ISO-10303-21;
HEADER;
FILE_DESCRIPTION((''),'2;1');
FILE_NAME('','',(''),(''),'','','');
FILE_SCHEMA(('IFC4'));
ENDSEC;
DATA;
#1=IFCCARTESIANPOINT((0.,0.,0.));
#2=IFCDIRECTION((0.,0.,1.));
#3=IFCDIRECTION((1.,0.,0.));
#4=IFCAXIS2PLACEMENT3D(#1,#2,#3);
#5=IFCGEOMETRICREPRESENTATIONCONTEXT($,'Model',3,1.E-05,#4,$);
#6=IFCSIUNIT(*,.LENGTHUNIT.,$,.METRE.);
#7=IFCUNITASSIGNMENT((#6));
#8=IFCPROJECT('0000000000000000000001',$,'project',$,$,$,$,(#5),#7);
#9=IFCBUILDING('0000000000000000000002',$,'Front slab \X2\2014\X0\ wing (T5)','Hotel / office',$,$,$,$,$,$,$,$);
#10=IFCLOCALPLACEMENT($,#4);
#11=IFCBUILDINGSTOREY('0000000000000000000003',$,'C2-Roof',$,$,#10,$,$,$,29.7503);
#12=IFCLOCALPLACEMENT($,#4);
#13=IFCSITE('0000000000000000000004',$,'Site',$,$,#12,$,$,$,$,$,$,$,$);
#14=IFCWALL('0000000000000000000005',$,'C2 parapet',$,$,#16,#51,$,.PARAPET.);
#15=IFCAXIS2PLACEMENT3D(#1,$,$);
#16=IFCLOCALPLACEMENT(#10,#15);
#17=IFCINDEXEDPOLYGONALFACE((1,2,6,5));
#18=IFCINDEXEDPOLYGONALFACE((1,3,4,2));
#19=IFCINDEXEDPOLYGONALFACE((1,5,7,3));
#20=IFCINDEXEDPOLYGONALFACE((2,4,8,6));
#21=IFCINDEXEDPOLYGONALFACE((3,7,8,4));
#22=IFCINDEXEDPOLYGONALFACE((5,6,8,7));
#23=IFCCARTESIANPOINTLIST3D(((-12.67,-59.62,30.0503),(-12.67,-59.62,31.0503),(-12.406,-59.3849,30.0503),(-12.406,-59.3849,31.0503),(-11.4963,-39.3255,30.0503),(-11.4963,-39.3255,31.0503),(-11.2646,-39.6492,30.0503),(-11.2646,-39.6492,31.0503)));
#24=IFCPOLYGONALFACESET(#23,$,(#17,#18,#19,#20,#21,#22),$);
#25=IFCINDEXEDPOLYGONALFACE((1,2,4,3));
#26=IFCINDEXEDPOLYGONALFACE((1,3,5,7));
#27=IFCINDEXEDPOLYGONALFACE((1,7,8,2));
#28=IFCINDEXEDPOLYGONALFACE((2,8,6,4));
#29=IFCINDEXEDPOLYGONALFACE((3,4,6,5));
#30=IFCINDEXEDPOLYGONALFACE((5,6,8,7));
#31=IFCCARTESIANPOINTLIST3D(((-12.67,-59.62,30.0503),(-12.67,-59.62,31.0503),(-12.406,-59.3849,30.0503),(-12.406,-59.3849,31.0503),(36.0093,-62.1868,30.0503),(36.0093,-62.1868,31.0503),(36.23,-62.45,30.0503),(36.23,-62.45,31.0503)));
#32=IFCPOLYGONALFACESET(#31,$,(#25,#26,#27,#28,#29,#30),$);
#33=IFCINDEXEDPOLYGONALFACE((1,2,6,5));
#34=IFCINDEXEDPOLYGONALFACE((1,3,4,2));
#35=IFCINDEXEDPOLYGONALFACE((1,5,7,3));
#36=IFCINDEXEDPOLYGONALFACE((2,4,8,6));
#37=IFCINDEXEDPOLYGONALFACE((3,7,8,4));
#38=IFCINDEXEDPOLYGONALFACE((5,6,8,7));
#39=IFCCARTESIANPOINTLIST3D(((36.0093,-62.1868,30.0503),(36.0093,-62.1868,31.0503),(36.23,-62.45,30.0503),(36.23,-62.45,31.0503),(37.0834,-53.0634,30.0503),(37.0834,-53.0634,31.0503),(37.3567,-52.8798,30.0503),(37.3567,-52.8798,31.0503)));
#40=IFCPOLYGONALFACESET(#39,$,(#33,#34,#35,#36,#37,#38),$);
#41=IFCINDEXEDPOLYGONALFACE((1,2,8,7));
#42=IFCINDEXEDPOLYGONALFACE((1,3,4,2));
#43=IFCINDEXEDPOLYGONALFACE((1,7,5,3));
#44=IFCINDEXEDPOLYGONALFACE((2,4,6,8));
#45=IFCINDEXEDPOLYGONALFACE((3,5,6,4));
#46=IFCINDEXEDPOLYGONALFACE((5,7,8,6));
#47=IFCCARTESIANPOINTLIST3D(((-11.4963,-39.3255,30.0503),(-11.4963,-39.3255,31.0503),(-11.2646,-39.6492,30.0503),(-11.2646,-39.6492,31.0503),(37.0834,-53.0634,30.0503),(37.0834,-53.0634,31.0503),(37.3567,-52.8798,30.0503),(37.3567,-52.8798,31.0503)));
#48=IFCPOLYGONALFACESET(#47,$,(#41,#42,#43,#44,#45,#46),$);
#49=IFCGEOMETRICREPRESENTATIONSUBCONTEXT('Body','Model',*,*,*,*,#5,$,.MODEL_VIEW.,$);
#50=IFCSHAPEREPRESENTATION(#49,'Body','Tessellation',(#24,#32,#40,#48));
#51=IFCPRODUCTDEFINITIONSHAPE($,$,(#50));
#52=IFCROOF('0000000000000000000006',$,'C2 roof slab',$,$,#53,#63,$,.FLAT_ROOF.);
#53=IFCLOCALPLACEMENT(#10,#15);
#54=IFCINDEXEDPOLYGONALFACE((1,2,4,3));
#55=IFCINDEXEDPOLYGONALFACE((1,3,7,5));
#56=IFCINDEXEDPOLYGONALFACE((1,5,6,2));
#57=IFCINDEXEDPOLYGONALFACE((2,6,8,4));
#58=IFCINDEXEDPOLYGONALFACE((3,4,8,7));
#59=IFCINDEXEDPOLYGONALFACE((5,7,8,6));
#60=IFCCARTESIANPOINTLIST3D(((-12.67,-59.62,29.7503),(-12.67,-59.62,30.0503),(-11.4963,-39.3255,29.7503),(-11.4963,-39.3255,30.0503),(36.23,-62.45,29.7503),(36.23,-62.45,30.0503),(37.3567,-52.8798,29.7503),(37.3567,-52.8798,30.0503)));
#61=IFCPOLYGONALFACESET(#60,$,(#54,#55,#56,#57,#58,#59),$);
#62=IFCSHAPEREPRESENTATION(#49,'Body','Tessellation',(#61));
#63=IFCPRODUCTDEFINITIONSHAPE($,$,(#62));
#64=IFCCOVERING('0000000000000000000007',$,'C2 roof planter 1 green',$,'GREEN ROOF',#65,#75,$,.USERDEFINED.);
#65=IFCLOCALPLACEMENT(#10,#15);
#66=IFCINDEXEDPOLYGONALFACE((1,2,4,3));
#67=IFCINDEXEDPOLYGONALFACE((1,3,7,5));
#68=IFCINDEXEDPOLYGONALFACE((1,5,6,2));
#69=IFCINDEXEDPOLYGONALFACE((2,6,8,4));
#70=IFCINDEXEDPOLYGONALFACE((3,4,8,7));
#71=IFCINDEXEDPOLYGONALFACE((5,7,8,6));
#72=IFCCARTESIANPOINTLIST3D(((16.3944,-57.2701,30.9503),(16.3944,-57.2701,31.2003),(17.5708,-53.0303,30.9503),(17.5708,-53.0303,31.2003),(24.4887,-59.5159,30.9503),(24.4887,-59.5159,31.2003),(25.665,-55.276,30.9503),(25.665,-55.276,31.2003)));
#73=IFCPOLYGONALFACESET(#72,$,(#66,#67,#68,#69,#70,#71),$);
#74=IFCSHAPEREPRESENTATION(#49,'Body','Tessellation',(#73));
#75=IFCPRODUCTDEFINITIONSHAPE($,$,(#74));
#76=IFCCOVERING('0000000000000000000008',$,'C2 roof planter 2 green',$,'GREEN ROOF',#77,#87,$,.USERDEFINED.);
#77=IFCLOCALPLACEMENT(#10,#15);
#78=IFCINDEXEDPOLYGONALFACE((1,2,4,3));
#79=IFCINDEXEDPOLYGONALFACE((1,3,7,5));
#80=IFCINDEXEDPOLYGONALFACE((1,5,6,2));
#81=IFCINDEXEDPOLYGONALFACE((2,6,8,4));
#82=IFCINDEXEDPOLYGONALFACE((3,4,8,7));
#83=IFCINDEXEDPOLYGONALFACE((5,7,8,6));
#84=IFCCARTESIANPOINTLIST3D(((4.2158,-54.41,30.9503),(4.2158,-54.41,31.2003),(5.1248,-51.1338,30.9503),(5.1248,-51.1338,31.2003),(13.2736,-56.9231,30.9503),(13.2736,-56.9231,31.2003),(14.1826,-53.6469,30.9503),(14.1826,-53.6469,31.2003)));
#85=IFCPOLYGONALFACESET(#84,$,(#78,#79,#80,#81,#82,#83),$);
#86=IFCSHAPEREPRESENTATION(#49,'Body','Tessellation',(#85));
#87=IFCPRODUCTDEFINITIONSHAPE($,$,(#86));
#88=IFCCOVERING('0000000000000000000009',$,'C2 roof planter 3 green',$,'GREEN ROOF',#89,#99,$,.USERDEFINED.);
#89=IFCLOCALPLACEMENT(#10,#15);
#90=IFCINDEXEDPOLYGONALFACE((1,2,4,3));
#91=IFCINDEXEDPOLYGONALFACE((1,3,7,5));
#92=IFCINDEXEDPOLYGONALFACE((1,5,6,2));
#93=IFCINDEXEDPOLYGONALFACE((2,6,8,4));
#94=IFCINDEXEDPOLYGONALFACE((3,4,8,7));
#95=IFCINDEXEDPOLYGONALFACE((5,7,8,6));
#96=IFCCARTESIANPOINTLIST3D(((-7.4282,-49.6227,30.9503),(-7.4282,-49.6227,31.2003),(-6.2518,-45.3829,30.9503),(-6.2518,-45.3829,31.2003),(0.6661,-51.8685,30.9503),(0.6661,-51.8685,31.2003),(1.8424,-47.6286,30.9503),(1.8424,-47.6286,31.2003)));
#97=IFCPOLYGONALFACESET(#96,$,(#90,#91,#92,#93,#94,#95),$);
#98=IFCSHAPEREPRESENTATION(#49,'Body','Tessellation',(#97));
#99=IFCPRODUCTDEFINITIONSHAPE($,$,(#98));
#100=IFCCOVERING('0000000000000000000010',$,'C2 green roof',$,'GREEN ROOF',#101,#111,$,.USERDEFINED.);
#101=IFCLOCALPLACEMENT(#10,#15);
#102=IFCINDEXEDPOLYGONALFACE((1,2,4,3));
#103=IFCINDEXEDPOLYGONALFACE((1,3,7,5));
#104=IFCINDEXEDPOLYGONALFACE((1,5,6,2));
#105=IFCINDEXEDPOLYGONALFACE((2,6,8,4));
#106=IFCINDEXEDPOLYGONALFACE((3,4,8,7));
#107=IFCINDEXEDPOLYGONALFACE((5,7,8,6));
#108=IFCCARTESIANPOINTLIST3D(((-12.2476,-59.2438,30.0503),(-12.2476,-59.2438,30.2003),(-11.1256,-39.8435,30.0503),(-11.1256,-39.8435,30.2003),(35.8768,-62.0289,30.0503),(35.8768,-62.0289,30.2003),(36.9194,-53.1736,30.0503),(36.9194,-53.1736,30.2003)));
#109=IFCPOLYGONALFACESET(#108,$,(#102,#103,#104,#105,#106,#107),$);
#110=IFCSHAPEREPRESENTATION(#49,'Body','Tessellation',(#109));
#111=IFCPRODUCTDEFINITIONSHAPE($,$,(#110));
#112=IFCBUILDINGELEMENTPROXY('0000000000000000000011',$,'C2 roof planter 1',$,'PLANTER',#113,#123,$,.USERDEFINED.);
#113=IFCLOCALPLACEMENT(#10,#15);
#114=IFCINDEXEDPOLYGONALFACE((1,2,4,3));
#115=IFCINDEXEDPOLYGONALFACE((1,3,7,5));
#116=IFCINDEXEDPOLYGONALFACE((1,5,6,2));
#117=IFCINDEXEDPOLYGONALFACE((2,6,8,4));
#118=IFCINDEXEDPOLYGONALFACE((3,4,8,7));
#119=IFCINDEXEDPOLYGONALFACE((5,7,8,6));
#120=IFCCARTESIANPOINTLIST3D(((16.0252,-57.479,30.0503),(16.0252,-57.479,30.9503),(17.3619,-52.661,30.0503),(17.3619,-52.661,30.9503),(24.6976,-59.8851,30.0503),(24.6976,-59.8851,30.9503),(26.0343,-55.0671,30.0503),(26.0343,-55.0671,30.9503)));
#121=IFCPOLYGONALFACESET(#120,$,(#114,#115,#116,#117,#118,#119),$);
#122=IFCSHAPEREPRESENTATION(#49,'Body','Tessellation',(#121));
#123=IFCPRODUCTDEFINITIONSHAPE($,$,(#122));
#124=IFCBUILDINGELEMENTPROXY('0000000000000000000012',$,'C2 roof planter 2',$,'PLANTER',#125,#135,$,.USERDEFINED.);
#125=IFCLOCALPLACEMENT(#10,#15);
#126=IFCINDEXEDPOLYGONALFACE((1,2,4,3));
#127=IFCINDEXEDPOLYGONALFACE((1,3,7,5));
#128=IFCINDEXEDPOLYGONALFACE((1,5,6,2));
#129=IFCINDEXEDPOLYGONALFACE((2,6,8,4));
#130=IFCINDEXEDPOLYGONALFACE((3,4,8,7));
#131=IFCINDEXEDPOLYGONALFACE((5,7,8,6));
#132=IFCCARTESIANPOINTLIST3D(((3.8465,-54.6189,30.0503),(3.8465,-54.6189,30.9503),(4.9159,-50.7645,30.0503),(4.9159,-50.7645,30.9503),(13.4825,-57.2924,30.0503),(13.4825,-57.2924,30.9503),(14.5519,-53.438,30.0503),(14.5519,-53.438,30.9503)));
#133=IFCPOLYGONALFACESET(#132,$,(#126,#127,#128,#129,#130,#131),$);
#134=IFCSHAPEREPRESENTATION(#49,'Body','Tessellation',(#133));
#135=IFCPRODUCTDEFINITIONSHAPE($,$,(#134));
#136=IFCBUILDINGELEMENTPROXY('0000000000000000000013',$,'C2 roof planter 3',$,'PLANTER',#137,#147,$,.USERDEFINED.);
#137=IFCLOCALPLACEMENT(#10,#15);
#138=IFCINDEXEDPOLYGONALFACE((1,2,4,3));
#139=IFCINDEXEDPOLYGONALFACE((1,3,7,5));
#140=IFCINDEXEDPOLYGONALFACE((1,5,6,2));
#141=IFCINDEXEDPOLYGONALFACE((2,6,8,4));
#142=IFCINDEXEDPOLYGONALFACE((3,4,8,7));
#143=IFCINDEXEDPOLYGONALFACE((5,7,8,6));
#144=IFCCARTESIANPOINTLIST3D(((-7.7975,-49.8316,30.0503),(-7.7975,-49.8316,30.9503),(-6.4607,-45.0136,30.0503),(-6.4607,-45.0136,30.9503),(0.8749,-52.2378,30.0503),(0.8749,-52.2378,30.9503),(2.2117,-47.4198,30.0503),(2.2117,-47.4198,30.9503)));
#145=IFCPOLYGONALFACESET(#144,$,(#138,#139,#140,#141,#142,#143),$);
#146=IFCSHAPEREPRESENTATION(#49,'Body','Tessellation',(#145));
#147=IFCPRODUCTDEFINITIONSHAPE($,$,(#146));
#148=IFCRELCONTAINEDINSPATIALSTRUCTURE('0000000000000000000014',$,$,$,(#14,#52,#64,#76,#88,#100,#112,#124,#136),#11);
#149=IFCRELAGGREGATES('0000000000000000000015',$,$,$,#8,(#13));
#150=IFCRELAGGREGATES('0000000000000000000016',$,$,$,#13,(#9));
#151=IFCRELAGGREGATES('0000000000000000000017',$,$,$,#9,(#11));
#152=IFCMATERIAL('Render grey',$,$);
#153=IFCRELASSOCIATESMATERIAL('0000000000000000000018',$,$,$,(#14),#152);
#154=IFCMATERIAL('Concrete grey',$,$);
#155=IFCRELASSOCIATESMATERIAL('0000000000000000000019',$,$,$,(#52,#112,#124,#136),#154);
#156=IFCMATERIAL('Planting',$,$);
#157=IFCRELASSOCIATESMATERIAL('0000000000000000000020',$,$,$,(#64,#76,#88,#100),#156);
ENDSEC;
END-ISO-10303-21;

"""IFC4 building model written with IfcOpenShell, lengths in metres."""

from ifc_helpers import new_model, si_unit, frame, origin_with_axes, place, context, subcontext, project, spatial, polyline, outline, extrude, material, element, save


model = new_model("IFC4")

# Units and contexts
model_context = context("Model", 3, precision=1e-05, world=origin_with_axes())
body_context = subcontext(model_context, "Body", "Model", "MODEL_VIEW")
ifc_project = project(units=[si_unit("LENGTHUNIT", "METRE")], contexts=[model_context])

# Site, building, storey
site_placement = place(None, origin_with_axes())
site = spatial("IfcSite", under=ifc_project, at=site_placement, Name="Site")
building = spatial("IfcBuilding", under=site, Name="Front slab — wing (T5)", Description="Hotel / office")
storey_placement = place(None, origin_with_axes())
storey = spatial("IfcBuildingStorey", under=building, at=storey_placement, Name="C2-Roof", Elevation=29.7503)

# Wall
ifc_material_1 = material(Name="Render grey")
wall_placement = place(storey_placement, origin_with_axes())
element("IfcWall", 1, at=wall_placement, inside=storey, material=ifc_material_1, Name="C2 parapet", PredefinedType="PARAPET", context=body_context, shape_type="SweptSolid", body=[
    extrude(outline(polyline([(-11.4963, -39.3255), (-12.67, -59.62), (-12.406, -59.3849), (-11.2646, -39.6492), (-11.4963, -39.3255)])), frame((0.0, 0.0, 30.0503), z_axis=(0.0, 0.0, 1.0), x_axis=(1.0, 0.0, 0.0)), (0.0, 0.0, 1.0), 1.0),
    extrude(outline(polyline([(-12.67, -59.62), (36.23, -62.45), (36.0093, -62.1868), (-12.406, -59.3849), (-12.67, -59.62)])), frame((0.0, 0.0, 30.0503), z_axis=(0.0, 0.0, 1.0), x_axis=(1.0, 0.0, 0.0)), (0.0, 0.0, 1.0), 1.0),
    extrude(outline(polyline([(36.23, -62.45), (37.3567, -52.8798), (37.0834, -53.0634), (36.0093, -62.1868), (36.23, -62.45)])), frame((0.0, 0.0, 30.0503), z_axis=(0.0, 0.0, 1.0), x_axis=(1.0, 0.0, 0.0)), (0.0, 0.0, 1.0), 1.0),
    extrude(outline(polyline([(37.3567, -52.8798), (-11.4963, -39.3255), (-11.2646, -39.6492), (37.0834, -53.0634), (37.3567, -52.8798)])), frame((0.0, 0.0, 30.0503), z_axis=(0.0, 0.0, 1.0), x_axis=(1.0, 0.0, 0.0)), (0.0, 0.0, 1.0), 1.0),
])

# Roof
ifc_material_2 = material(Name="Concrete grey")
roof_placement = place(storey_placement, origin_with_axes())
element("IfcRoof", 2, at=roof_placement, inside=storey, material=ifc_material_2, Name="C2 roof slab", PredefinedType="FLAT_ROOF", context=body_context, shape_type="SweptSolid", body=[
    extrude(outline(polyline([(-11.4963, -39.3255), (-12.67, -59.62), (36.23, -62.45), (37.3567, -52.8798), (-11.4963, -39.3255)])), frame((0.0, 0.0, 29.7503), z_axis=(0.0, 0.0, 1.0), x_axis=(1.0, 0.0, 0.0)), (0.0, 0.0, 1.0), 0.3),
])

# Coverings
ifc_material_3 = material(Name="Planting")
covering_1_placement = place(storey_placement, origin_with_axes())
element("IfcCovering", 3, at=covering_1_placement, inside=storey, material=ifc_material_3, Name="C2 roof planter 1 green", ObjectType="GREEN ROOF", PredefinedType="USERDEFINED", context=body_context, shape_type="SweptSolid", body=[
    extrude(outline(polyline([(25.665, -55.276), (17.5708, -53.0303), (16.3944, -57.2701), (24.4887, -59.5159), (25.665, -55.276)])), frame((0.0, 0.0, 30.9503), z_axis=(0.0, 0.0, 1.0), x_axis=(1.0, 0.0, 0.0)), (0.0, 0.0, 1.0), 0.25),
])
covering_2_placement = place(storey_placement, origin_with_axes())
element("IfcCovering", 4, at=covering_2_placement, inside=storey, material=ifc_material_3, Name="C2 roof planter 2 green", ObjectType="GREEN ROOF", PredefinedType="USERDEFINED", context=body_context, shape_type="SweptSolid", body=[
    extrude(outline(polyline([(14.1826, -53.6469), (5.1248, -51.1338), (4.2158, -54.41), (13.2736, -56.9231), (14.1826, -53.6469)])), frame((0.0, 0.0, 30.9503), z_axis=(0.0, 0.0, 1.0), x_axis=(1.0, 0.0, 0.0)), (0.0, 0.0, 1.0), 0.25),
])
covering_3_placement = place(storey_placement, origin_with_axes())
element("IfcCovering", 5, at=covering_3_placement, inside=storey, material=ifc_material_3, Name="C2 roof planter 3 green", ObjectType="GREEN ROOF", PredefinedType="USERDEFINED", context=body_context, shape_type="SweptSolid", body=[
    extrude(outline(polyline([(1.8424, -47.6286), (-6.2518, -45.3829), (-7.4282, -49.6227), (0.6661, -51.8685), (1.8424, -47.6286)])), frame((0.0, 0.0, 30.9503), z_axis=(0.0, 0.0, 1.0), x_axis=(1.0, 0.0, 0.0)), (0.0, 0.0, 1.0), 0.25),
])
covering_4_placement = place(storey_placement, origin_with_axes())
element("IfcCovering", 6, at=covering_4_placement, inside=storey, material=ifc_material_3, Name="C2 green roof", ObjectType="GREEN ROOF", PredefinedType="USERDEFINED", context=body_context, shape_type="SweptSolid", body=[
    extrude(outline(polyline([(-11.1256, -39.8435), (-12.2476, -59.2438), (35.8768, -62.0289), (36.9194, -53.1736), (-11.1256, -39.8435)])), frame((0.0, 0.0, 30.0503), z_axis=(0.0, 0.0, 1.0), x_axis=(1.0, 0.0, 0.0)), (0.0, 0.0, 1.0), 0.15),
])

# Building element proxies
proxy_1_placement = place(storey_placement, origin_with_axes())
element("IfcBuildingElementProxy", 7, at=proxy_1_placement, inside=storey, material=ifc_material_2, Name="C2 roof planter 1", ObjectType="PLANTER", PredefinedType="USERDEFINED", context=body_context, shape_type="SweptSolid", body=[
    extrude(outline(polyline([(26.0343, -55.0671), (17.3619, -52.661), (16.0252, -57.479), (24.6976, -59.8851), (26.0343, -55.0671)])), frame((0.0, 0.0, 30.0503), z_axis=(0.0, 0.0, 1.0), x_axis=(1.0, 0.0, 0.0)), (0.0, 0.0, 1.0), 0.9),
])
proxy_2_placement = place(storey_placement, origin_with_axes())
element("IfcBuildingElementProxy", 8, at=proxy_2_placement, inside=storey, material=ifc_material_2, Name="C2 roof planter 2", ObjectType="PLANTER", PredefinedType="USERDEFINED", context=body_context, shape_type="SweptSolid", body=[
    extrude(outline(polyline([(14.5519, -53.438), (4.9159, -50.7645), (3.8465, -54.6189), (13.4825, -57.2924), (14.5519, -53.438)])), frame((0.0, 0.0, 30.0503), z_axis=(0.0, 0.0, 1.0), x_axis=(1.0, 0.0, 0.0)), (0.0, 0.0, 1.0), 0.9),
])
proxy_3_placement = place(storey_placement, origin_with_axes())
element("IfcBuildingElementProxy", 9, at=proxy_3_placement, inside=storey, material=ifc_material_2, Name="C2 roof planter 3", ObjectType="PLANTER", PredefinedType="USERDEFINED", context=body_context, shape_type="SweptSolid", body=[
    extrude(outline(polyline([(2.2117, -47.4198), (-6.4607, -45.0136), (-7.7975, -49.8316), (0.8749, -52.2378), (2.2117, -47.4198)])), frame((0.0, 0.0, 30.0503), z_axis=(0.0, 0.0, 1.0), x_axis=(1.0, 0.0, 0.0)), (0.0, 0.0, 1.0), 0.9),
])

save(model, "model.ifc")
